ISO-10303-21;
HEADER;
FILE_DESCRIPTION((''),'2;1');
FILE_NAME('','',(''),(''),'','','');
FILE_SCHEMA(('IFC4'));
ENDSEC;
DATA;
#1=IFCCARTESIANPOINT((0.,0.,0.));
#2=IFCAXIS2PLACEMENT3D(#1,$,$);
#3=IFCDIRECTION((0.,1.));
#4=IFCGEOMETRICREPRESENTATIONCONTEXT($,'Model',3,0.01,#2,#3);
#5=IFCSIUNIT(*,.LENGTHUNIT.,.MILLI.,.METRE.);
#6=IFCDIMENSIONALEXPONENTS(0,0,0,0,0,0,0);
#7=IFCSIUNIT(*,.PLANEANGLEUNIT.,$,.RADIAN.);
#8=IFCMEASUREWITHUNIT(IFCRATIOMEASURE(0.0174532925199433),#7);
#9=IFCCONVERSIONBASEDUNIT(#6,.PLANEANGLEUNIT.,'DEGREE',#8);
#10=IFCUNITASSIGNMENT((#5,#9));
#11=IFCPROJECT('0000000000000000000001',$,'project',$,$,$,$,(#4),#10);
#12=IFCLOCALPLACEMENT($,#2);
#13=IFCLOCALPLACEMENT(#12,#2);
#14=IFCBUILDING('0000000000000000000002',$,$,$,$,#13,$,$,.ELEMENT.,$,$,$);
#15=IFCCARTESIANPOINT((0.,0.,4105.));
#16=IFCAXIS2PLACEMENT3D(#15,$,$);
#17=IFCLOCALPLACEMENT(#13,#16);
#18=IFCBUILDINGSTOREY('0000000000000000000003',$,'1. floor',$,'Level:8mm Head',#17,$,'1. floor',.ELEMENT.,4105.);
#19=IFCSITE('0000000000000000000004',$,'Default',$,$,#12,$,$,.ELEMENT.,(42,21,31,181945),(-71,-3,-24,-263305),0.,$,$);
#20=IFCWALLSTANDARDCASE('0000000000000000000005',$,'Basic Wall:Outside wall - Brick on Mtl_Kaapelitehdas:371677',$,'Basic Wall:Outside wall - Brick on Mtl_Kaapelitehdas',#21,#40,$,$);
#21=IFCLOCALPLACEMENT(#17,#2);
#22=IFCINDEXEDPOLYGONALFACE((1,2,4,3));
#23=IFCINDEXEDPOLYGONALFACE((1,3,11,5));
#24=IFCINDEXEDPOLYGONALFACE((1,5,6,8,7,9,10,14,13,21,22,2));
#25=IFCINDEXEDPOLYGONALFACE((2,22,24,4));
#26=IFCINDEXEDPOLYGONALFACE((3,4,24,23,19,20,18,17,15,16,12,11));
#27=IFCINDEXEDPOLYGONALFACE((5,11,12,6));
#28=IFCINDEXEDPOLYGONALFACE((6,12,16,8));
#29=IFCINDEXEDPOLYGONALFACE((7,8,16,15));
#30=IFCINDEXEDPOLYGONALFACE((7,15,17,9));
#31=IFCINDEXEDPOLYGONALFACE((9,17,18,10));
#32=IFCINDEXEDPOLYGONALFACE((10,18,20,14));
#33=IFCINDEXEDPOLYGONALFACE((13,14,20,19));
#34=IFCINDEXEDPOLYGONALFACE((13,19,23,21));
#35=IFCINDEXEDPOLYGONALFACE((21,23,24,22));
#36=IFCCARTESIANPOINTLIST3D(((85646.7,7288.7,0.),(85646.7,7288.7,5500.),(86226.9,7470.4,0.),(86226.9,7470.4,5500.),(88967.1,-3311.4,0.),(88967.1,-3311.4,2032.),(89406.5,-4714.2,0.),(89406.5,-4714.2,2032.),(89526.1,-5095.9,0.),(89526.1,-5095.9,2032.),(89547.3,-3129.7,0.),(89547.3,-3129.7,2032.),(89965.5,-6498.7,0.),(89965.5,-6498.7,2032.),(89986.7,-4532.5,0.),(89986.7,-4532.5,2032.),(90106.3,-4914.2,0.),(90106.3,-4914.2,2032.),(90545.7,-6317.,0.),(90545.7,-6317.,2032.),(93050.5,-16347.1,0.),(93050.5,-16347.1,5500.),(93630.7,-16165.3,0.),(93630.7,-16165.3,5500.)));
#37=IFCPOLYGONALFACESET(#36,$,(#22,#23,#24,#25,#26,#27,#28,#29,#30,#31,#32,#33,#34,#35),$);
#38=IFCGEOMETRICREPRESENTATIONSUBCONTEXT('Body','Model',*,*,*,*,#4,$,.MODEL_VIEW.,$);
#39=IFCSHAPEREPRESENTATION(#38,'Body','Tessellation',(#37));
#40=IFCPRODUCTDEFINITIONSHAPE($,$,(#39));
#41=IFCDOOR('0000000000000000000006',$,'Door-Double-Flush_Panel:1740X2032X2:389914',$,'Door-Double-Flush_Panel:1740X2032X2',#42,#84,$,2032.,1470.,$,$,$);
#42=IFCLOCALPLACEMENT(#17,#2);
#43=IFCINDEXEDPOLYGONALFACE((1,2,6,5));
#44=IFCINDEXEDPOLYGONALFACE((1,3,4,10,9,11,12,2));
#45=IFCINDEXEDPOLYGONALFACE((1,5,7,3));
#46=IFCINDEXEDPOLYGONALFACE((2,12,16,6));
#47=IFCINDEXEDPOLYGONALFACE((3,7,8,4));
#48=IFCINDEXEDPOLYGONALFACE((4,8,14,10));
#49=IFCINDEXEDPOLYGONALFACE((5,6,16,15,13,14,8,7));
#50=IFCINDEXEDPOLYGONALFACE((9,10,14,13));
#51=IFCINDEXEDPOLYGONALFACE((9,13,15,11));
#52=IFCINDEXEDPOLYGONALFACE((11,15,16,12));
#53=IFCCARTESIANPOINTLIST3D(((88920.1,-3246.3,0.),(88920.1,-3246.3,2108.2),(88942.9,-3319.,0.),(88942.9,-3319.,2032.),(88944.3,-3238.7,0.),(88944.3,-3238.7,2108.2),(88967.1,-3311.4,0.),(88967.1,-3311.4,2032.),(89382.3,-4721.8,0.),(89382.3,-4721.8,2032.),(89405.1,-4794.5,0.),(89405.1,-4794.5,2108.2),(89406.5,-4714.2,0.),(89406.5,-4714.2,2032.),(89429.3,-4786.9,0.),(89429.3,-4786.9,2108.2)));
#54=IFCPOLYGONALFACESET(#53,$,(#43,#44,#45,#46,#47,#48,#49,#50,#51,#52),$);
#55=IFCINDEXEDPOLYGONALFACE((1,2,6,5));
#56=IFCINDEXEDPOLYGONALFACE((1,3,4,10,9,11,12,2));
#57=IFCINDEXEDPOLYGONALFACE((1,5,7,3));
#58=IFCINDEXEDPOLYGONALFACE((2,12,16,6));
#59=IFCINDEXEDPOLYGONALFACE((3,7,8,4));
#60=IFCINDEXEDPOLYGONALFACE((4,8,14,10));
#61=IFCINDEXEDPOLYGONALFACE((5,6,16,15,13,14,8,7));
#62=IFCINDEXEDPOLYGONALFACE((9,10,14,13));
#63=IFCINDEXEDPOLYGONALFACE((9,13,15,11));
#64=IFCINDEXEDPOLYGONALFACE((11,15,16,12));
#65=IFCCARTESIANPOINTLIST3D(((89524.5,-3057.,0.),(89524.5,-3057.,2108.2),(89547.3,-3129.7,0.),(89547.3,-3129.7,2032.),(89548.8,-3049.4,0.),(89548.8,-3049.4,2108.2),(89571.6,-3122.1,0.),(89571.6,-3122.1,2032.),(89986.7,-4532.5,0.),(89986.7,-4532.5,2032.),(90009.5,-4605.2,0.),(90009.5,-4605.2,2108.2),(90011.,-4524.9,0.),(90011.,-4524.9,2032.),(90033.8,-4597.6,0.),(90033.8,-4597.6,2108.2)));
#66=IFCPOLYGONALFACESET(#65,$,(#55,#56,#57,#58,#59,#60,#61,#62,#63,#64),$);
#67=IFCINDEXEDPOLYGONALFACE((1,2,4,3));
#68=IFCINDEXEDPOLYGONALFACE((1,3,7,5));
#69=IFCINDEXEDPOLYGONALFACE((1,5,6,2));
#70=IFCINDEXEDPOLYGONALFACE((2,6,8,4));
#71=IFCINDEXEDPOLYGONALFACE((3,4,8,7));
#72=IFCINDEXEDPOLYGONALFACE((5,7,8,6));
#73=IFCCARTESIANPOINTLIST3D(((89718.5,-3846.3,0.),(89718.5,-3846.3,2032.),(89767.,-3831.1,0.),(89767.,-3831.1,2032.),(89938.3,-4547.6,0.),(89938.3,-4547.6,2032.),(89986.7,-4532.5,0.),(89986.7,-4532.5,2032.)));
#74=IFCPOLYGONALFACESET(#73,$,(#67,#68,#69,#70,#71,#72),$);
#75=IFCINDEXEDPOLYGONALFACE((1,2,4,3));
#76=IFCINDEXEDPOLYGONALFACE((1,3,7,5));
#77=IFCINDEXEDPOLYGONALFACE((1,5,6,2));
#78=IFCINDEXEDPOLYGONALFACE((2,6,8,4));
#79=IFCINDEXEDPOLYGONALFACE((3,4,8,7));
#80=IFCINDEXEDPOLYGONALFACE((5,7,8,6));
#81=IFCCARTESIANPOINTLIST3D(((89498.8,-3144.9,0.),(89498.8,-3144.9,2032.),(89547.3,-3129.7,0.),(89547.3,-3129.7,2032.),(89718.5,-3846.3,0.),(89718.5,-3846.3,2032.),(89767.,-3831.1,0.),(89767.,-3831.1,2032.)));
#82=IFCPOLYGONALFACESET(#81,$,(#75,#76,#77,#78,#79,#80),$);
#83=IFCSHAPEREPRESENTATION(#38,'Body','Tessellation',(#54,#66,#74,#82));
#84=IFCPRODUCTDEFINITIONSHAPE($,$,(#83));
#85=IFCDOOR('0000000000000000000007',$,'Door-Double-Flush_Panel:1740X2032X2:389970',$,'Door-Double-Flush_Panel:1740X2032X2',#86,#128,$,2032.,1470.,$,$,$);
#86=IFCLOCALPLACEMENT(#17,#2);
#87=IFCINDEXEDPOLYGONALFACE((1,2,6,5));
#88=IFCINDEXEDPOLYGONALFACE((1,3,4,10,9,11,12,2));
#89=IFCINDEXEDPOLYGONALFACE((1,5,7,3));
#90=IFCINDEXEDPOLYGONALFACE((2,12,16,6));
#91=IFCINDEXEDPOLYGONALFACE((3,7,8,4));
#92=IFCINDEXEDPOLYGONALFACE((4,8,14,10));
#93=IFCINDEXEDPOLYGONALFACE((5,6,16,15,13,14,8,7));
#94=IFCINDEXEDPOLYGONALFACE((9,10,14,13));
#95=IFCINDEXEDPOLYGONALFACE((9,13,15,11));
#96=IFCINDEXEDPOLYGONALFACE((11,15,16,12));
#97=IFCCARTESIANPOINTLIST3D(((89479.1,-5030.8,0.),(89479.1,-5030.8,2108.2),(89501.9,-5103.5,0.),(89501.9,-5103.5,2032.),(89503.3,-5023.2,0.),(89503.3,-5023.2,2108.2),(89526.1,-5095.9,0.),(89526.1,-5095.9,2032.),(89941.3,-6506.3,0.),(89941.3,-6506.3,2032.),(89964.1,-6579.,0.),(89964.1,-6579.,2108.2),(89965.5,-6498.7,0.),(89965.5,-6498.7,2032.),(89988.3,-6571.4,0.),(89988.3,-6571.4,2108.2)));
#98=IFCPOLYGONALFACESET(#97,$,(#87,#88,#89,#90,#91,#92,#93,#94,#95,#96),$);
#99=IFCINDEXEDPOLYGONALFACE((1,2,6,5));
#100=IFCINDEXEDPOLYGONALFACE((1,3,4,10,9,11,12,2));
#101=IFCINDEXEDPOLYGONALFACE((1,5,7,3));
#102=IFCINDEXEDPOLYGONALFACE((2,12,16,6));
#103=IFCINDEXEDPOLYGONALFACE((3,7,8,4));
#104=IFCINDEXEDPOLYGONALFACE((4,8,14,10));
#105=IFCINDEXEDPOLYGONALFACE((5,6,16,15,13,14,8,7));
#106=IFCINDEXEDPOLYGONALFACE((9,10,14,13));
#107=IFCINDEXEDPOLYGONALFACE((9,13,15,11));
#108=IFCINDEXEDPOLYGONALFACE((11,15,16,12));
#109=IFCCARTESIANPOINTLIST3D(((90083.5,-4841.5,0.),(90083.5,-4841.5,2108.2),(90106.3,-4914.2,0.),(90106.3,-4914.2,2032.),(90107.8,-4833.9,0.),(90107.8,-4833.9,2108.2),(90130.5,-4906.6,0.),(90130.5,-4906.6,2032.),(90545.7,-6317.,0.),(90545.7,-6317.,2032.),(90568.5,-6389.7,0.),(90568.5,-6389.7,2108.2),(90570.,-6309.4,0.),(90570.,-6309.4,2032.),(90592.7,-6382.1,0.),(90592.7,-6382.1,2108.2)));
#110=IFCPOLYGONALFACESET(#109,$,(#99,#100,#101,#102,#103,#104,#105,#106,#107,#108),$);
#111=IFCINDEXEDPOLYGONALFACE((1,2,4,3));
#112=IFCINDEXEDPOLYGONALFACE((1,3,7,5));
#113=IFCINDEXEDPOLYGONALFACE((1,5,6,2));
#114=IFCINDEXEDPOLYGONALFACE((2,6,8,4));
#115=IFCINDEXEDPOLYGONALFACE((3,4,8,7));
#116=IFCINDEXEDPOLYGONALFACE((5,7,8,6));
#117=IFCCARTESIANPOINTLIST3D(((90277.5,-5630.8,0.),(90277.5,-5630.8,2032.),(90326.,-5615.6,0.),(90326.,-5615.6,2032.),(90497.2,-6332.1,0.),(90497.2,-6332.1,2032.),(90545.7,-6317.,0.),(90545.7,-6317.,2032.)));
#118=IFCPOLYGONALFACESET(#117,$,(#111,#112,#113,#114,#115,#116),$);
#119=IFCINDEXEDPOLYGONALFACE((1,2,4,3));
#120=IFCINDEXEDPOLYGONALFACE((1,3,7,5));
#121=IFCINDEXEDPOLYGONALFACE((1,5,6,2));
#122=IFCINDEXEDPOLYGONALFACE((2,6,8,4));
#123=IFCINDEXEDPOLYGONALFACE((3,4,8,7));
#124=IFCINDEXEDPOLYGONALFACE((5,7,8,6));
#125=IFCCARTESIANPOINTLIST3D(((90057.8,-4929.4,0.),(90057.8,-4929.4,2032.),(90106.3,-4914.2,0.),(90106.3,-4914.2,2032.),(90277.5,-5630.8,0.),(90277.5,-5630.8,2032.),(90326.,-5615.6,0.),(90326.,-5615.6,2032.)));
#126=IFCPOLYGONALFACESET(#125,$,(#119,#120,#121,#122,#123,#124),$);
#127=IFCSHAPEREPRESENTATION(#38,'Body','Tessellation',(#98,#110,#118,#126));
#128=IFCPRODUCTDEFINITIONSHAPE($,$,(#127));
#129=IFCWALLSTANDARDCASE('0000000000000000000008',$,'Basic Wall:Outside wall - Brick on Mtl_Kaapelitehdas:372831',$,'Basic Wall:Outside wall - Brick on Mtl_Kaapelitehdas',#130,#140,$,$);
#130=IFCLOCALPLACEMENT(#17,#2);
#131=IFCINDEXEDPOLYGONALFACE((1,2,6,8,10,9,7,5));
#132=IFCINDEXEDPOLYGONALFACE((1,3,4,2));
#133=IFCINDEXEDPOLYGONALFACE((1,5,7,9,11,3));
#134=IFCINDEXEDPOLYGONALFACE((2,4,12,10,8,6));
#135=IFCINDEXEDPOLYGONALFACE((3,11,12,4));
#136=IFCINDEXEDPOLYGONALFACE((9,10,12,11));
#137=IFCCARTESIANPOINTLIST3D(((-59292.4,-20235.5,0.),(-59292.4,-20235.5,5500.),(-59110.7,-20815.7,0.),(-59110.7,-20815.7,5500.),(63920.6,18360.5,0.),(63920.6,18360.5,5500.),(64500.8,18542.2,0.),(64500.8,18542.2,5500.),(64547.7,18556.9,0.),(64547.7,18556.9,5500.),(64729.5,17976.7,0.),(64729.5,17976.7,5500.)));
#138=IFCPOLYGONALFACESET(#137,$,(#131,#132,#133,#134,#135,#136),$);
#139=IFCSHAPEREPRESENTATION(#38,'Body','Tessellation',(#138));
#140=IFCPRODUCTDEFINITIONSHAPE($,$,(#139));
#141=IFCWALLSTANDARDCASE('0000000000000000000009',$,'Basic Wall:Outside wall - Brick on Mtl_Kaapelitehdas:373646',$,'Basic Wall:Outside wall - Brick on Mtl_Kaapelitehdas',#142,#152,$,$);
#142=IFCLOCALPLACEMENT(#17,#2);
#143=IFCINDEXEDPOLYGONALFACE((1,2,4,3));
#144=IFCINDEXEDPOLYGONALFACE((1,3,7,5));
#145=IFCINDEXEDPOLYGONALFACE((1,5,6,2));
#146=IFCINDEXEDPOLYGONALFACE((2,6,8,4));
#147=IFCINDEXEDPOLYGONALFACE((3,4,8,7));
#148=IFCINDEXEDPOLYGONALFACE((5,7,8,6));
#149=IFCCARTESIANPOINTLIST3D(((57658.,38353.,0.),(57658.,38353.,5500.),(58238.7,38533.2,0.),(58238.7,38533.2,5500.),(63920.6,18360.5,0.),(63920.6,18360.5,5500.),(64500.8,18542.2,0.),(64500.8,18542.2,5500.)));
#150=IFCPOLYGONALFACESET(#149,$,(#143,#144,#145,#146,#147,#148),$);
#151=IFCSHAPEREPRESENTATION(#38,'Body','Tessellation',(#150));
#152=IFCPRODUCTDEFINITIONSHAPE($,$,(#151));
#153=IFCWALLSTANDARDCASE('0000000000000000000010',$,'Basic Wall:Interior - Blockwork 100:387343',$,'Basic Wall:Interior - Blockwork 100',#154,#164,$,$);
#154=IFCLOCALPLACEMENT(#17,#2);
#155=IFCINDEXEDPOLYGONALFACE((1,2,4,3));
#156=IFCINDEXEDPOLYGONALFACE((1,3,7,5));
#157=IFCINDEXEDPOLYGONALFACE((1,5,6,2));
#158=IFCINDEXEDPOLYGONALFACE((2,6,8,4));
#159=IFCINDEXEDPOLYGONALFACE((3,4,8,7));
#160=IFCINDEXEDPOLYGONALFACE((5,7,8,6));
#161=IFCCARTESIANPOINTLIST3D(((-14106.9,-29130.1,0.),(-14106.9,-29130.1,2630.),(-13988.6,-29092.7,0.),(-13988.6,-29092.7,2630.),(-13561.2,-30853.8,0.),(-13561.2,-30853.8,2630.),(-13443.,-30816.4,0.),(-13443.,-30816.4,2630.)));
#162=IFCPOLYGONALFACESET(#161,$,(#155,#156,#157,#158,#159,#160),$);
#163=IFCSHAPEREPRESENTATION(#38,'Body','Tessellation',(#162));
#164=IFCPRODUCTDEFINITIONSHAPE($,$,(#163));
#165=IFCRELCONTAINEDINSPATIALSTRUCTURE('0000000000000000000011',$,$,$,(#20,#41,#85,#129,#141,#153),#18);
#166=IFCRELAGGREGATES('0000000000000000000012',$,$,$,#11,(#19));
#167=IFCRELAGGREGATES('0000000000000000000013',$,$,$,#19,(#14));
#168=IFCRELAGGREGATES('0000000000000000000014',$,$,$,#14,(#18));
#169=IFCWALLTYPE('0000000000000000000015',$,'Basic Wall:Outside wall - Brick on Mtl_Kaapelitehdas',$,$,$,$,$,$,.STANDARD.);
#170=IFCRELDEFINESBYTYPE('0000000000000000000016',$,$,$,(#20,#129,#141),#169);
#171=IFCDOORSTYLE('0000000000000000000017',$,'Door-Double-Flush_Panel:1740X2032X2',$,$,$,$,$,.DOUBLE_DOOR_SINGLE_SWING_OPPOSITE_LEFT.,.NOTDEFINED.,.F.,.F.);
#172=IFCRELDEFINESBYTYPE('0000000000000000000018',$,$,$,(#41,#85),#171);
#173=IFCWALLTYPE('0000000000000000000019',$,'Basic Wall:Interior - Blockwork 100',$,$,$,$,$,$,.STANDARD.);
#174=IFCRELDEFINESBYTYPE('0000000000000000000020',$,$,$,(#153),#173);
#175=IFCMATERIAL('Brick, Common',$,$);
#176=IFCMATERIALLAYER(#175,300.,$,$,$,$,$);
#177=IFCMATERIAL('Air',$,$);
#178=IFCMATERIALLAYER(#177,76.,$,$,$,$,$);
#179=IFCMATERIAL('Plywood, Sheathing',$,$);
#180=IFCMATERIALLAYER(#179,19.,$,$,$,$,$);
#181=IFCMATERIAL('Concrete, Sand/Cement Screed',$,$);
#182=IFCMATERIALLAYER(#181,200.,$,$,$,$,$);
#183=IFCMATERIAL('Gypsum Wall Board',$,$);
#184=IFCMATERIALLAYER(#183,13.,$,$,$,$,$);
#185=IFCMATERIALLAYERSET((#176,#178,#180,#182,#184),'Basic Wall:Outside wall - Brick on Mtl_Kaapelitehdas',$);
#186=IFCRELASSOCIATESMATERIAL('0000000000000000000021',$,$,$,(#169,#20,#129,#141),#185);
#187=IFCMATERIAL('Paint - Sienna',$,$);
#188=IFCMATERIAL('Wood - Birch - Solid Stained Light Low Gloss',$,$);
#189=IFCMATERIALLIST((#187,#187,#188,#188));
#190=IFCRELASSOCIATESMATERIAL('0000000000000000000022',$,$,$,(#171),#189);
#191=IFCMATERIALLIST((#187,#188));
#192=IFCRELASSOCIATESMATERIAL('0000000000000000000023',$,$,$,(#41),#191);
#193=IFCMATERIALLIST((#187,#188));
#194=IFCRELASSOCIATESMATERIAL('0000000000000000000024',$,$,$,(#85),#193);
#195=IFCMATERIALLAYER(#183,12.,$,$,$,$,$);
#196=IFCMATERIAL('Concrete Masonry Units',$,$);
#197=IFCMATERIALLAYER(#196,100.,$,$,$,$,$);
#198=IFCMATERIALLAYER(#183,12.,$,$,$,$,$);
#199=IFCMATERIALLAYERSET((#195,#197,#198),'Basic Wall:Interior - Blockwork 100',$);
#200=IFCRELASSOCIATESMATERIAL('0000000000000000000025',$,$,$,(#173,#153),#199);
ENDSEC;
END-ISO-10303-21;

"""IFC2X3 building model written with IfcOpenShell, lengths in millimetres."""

from ifc_helpers import new_model, entity, si_unit, converted_unit, direction, frame, frame_2d, origin, origin_2d_with_axis, place, context, subcontext, project, spatial, polyline, rectangle, outline, extrude, source, transform, mapped, material, material_list, layer, layer_set, layer_usage, type_object, type_shapes, element, fill, save


model = new_model("IFC2X3")

# Units and contexts
model_context = context("Model", 3, precision=0.01, world=origin(), true_north=direction((0.0, 1.0)))
body_context = subcontext(model_context, "Body", "Model", "MODEL_VIEW")
ifc_project = project(units=[si_unit("LENGTHUNIT", "METRE", prefix="MILLI"), converted_unit("PLANEANGLEUNIT", "DEGREE", entity("IfcRatioMeasure", 0.0174532925199433), si_unit("PLANEANGLEUNIT", "RADIAN"), dimensions=[0, 0, 0, 0, 0, 0, 0])], contexts=[model_context])

# Site, building, storey
site_placement = place(None, origin())
site = spatial("IfcSite", under=ifc_project, at=site_placement, Name="Default", CompositionType="ELEMENT", RefLatitude=(42, 21, 31, 181945), RefLongitude=(-71, -3, -24, -263305), RefElevation=0.0)
building_placement = place(site_placement, origin())
building = spatial("IfcBuilding", under=site, at=building_placement, CompositionType="ELEMENT")
storey_placement = place(building_placement, frame((0.0, 0.0, 4105.0)))
storey = spatial("IfcBuildingStorey", under=building, at=storey_placement, Name="1. floor", ObjectType="Level:8mm Head", LongName="1. floor", CompositionType="ELEMENT", Elevation=4105.0)

# Wall, openings, doors
ifc_material_1 = material(Name="Brick, Common")
ifc_layer_1 = layer(ifc_material_1, 300.0)
ifc_material_2 = material(Name="Air")
ifc_layer_2 = layer(ifc_material_2, 76.0)
ifc_material_3 = material(Name="Plywood, Sheathing")
ifc_layer_3 = layer(ifc_material_3, 19.0)
ifc_material_4 = material(Name="Concrete, Sand/Cement Screed")
ifc_layer_4 = layer(ifc_material_4, 200.0)
ifc_material_5 = material(Name="Gypsum Wall Board")
ifc_layer_5 = layer(ifc_material_5, 13.0)
ifc_layer_set_1 = layer_set([ifc_layer_1, ifc_layer_2, ifc_layer_3, ifc_layer_4, ifc_layer_5], Name="Basic Wall:Outside wall - Brick on Mtl_Kaapelitehdas")
wall_type_1 = type_object("IfcWallType", Name="Basic Wall:Outside wall - Brick on Mtl_Kaapelitehdas", PredefinedType="STANDARD", material=ifc_layer_set_1)
ifc_material_6 = material(Name="Paint - Sienna")
ifc_material_7 = material(Name="Wood - Birch - Solid Stained Light Low Gloss")
ifc_material_list_1 = material_list([ifc_material_6, ifc_material_6, ifc_material_7, ifc_material_7])
door_style = type_object("IfcDoorStyle", Name="Door-Double-Flush_Panel:1740X2032X2", ConstructionType="NOTDEFINED", OperationType="DOUBLE_DOOR_SINGLE_SWING_OPPOSITE_LEFT", ParameterTakesPrecedence=False, Sizeable=False, material=ifc_material_list_1)
shared_shape = source(origin(), body_context, "Body", "SweptSolid", [
    extrude(outline(polyline([(-997.0, 735.0), (1035.0, 735.0), (1035.0, 811.2), (-1073.2, 811.2), (-1073.2, -811.2), (1035.0, -811.2), (1035.0, -735.0), (-997.0, -735.0), (-997.0, 735.0)])), frame((735.0, -25.4, 1035.0), z_axis=(0.0, 1.0, 0.0), x_axis=(0.0, 0.0, -1.0)), (0.0, 0.0, 1.0), 25.4),
    extrude(outline(polyline([(-997.0, 735.0), (1035.0, 735.0), (1035.0, 811.2), (-1073.2, 811.2), (-1073.2, -811.2), (1035.0, -811.2), (1035.0, -735.0), (-997.0, -735.0), (-997.0, 735.0)])), frame((735.0, 608.0, 1035.0), z_axis=(0.0, 1.0, 0.0), x_axis=(0.0, 0.0, -1.0)), (0.0, 0.0, 1.0), 25.4),
    extrude(rectangle(XDim=50.8, YDim=735.0, at=origin_2d_with_axis()), frame((1102.5, 582.6, 0.0), z_axis=(0.0, 0.0, 1.0), x_axis=(0.0, -1.0, 0.0)), (0.0, 0.0, 1.0), 2032.0),
    extrude(rectangle(XDim=50.8, YDim=735.0, at=frame_2d((0.0, 0.0), x_axis=(1.0, 0.0))), frame((367.5, 582.6, 0.0), z_axis=(0.0, 0.0, 1.0), x_axis=(0.0, -1.0, 0.0)), (0.0, 0.0, 1.0), 2032.0),
])
type_shapes(door_style, [shared_shape])
ifc_layer_usage_1 = layer_usage(ifc_layer_set_1, "AXIS2", "NEGATIVE", 304.0)
wall_1_placement = place(storey_placement, frame((85936.8, 7379.6, 0.0), z_axis=(0.0, 0.0, 1.0), x_axis=(0.298924, -0.954277, 0.0)))
wall_1 = element("IfcWallStandardCase", 1, at=wall_1_placement, inside=storey, type_object=wall_type_1, material=ifc_layer_usage_1, Name="Basic Wall:Outside wall - Brick on Mtl_Kaapelitehdas:371677", ObjectType="Basic Wall:Outside wall - Brick on Mtl_Kaapelitehdas", context=body_context, shape_type="SweptSolid", body=[
    extrude(rectangle(XDim=24768.2, YDim=608.0, at=frame_2d((12384.1, 0.0), x_axis=(-1.0, 0.0))), origin(), (0.0, 0.0, 1.0), 5500.0),
])
opening_1_placement = place(wall_1_placement, frame((11108.0, -304.0, 0.0)))
opening_1 = element("IfcOpeningElement", 2, at=opening_1_placement, cuts=wall_1, ObjectType="Opening", context=body_context, shape_type="SweptSolid", body=[
    extrude(rectangle(XDim=2032.0, YDim=1470.0, at=frame_2d((1016.0, 735.0), x_axis=(1.0, 0.0))), frame((0.0, 0.0, 0.0), z_axis=(0.0, 1.0, 0.0), x_axis=(0.0, 0.0, 1.0)), (0.0, 0.0, 1.0), 608.0),
])
opening_2_placement = place(wall_1_placement, frame((12978.0, -304.0, 0.0)))
opening_2 = element("IfcOpeningElement", 3, at=opening_2_placement, cuts=wall_1, ObjectType="Opening", context=body_context, shape_type="SweptSolid", body=[
    extrude(rectangle(XDim=2032.0, YDim=1470.0, at=frame_2d((1016.0, 735.0), x_axis=(1.0, 0.0))), frame((0.0, 0.0, 0.0), z_axis=(0.0, 1.0, 0.0), x_axis=(0.0, 0.0, 1.0)), (0.0, 0.0, 1.0), 608.0),
])
ifc_material_list_2 = material_list([ifc_material_6, ifc_material_7])
door_1_placement = place(opening_1_placement, origin())
door_1 = element("IfcDoor", 4, at=door_1_placement, inside=storey, type_object=door_style, material=ifc_material_list_2, Name="Door-Double-Flush_Panel:1740X2032X2:389914", ObjectType="Door-Double-Flush_Panel:1740X2032X2", OverallHeight=2032.0, OverallWidth=1470.0, context=body_context, shape_type="MappedRepresentation", body=[
    mapped(shared_shape, transform((0.0, 0.0, 0.0), scale=1.0)),
])
fill(opening_1, door_1)
ifc_material_list_3 = material_list([ifc_material_6, ifc_material_7])
door_2_placement = place(opening_2_placement, origin())
door_2 = element("IfcDoor", 5, at=door_2_placement, inside=storey, type_object=door_style, material=ifc_material_list_3, Name="Door-Double-Flush_Panel:1740X2032X2:389970", ObjectType="Door-Double-Flush_Panel:1740X2032X2", OverallHeight=2032.0, OverallWidth=1470.0, context=body_context, shape_type="MappedRepresentation", body=[
    mapped(shared_shape, transform((0.0, 0.0, 0.0), scale=1.0)),
])
fill(opening_2, door_2)

# Walls
ifc_layer_usage_2 = layer_usage(ifc_layer_set_1, "AXIS2", "NEGATIVE", 304.0)
wall_2_placement = place(storey_placement, frame((64638.6, 18266.8, 0.0), z_axis=(0.0, 0.0, 1.0), x_axis=(-0.954277, -0.298924, 0.0)))
element("IfcWallStandardCase", 6, at=wall_2_placement, inside=storey, type_object=wall_type_1, material=ifc_layer_usage_2, Name="Basic Wall:Outside wall - Brick on Mtl_Kaapelitehdas:372831", ObjectType="Basic Wall:Outside wall - Brick on Mtl_Kaapelitehdas", context=body_context, shape_type="SweptSolid", body=[
    extrude(outline(polyline([(129773.8, -304.0), (129773.9, 304.0), (0.0, 304.0), (0.0, -304.0), (49.2, -304.0), (657.2, -304.0), (129773.8, -304.0)])), origin(), (0.0, 0.0, 1.0), 5500.0),
])
ifc_layer_usage_3 = layer_usage(ifc_layer_set_1, "AXIS2", "NEGATIVE", 304.0)
wall_3_placement = place(storey_placement, frame((57948.1, 38443.9, 0.0), z_axis=(0.0, 0.0, 1.0), x_axis=(0.298924, -0.954277, 0.0)))
element("IfcWallStandardCase", 7, at=wall_3_placement, inside=storey, type_object=wall_type_1, material=ifc_layer_usage_3, Name="Basic Wall:Outside wall - Brick on Mtl_Kaapelitehdas:373646", ObjectType="Basic Wall:Outside wall - Brick on Mtl_Kaapelitehdas", context=body_context, shape_type="SweptSolid", body=[
    extrude(outline(polyline([(20950.4, -304.0), (20950.4, 304.0), (1.6, 304.0), (0.0, -304.0), (20950.4, -304.0)])), origin(), (0.0, 0.0, 1.0), 5500.0),
])
ifc_layer_6 = layer(ifc_material_5, 12.0)
ifc_material_8 = material(Name="Concrete Masonry Units")
ifc_layer_7 = layer(ifc_material_8, 100.0)
ifc_layer_8 = layer(ifc_material_5, 12.0)
ifc_layer_set_2 = layer_set([ifc_layer_6, ifc_layer_7, ifc_layer_8], Name="Basic Wall:Interior - Blockwork 100")
ifc_layer_usage_4 = layer_usage(ifc_layer_set_2, "AXIS2", "NEGATIVE", 62.0)
wall_type_2 = type_object("IfcWallType", Name="Basic Wall:Interior - Blockwork 100", PredefinedType="STANDARD", material=ifc_layer_set_2)
wall_4_placement = place(storey_placement, frame((-13502.1, -30835.1, 0.0), z_axis=(0.0, 0.0, 1.0), x_axis=(-0.301797, 0.953372, 0.0)))
element("IfcWallStandardCase", 8, at=wall_4_placement, inside=storey, type_object=wall_type_2, material=ifc_layer_usage_4, Name="Basic Wall:Interior - Blockwork 100:387343", ObjectType="Basic Wall:Interior - Blockwork 100", context=body_context, shape_type="SweptSolid", body=[
    extrude(rectangle(XDim=1808.0, YDim=124.0, at=frame_2d((904.0, 0.0), x_axis=(-1.0, 0.0))), origin(), (0.0, 0.0, 1.0), 2630.0),
])

save(model, "model.ifc")
